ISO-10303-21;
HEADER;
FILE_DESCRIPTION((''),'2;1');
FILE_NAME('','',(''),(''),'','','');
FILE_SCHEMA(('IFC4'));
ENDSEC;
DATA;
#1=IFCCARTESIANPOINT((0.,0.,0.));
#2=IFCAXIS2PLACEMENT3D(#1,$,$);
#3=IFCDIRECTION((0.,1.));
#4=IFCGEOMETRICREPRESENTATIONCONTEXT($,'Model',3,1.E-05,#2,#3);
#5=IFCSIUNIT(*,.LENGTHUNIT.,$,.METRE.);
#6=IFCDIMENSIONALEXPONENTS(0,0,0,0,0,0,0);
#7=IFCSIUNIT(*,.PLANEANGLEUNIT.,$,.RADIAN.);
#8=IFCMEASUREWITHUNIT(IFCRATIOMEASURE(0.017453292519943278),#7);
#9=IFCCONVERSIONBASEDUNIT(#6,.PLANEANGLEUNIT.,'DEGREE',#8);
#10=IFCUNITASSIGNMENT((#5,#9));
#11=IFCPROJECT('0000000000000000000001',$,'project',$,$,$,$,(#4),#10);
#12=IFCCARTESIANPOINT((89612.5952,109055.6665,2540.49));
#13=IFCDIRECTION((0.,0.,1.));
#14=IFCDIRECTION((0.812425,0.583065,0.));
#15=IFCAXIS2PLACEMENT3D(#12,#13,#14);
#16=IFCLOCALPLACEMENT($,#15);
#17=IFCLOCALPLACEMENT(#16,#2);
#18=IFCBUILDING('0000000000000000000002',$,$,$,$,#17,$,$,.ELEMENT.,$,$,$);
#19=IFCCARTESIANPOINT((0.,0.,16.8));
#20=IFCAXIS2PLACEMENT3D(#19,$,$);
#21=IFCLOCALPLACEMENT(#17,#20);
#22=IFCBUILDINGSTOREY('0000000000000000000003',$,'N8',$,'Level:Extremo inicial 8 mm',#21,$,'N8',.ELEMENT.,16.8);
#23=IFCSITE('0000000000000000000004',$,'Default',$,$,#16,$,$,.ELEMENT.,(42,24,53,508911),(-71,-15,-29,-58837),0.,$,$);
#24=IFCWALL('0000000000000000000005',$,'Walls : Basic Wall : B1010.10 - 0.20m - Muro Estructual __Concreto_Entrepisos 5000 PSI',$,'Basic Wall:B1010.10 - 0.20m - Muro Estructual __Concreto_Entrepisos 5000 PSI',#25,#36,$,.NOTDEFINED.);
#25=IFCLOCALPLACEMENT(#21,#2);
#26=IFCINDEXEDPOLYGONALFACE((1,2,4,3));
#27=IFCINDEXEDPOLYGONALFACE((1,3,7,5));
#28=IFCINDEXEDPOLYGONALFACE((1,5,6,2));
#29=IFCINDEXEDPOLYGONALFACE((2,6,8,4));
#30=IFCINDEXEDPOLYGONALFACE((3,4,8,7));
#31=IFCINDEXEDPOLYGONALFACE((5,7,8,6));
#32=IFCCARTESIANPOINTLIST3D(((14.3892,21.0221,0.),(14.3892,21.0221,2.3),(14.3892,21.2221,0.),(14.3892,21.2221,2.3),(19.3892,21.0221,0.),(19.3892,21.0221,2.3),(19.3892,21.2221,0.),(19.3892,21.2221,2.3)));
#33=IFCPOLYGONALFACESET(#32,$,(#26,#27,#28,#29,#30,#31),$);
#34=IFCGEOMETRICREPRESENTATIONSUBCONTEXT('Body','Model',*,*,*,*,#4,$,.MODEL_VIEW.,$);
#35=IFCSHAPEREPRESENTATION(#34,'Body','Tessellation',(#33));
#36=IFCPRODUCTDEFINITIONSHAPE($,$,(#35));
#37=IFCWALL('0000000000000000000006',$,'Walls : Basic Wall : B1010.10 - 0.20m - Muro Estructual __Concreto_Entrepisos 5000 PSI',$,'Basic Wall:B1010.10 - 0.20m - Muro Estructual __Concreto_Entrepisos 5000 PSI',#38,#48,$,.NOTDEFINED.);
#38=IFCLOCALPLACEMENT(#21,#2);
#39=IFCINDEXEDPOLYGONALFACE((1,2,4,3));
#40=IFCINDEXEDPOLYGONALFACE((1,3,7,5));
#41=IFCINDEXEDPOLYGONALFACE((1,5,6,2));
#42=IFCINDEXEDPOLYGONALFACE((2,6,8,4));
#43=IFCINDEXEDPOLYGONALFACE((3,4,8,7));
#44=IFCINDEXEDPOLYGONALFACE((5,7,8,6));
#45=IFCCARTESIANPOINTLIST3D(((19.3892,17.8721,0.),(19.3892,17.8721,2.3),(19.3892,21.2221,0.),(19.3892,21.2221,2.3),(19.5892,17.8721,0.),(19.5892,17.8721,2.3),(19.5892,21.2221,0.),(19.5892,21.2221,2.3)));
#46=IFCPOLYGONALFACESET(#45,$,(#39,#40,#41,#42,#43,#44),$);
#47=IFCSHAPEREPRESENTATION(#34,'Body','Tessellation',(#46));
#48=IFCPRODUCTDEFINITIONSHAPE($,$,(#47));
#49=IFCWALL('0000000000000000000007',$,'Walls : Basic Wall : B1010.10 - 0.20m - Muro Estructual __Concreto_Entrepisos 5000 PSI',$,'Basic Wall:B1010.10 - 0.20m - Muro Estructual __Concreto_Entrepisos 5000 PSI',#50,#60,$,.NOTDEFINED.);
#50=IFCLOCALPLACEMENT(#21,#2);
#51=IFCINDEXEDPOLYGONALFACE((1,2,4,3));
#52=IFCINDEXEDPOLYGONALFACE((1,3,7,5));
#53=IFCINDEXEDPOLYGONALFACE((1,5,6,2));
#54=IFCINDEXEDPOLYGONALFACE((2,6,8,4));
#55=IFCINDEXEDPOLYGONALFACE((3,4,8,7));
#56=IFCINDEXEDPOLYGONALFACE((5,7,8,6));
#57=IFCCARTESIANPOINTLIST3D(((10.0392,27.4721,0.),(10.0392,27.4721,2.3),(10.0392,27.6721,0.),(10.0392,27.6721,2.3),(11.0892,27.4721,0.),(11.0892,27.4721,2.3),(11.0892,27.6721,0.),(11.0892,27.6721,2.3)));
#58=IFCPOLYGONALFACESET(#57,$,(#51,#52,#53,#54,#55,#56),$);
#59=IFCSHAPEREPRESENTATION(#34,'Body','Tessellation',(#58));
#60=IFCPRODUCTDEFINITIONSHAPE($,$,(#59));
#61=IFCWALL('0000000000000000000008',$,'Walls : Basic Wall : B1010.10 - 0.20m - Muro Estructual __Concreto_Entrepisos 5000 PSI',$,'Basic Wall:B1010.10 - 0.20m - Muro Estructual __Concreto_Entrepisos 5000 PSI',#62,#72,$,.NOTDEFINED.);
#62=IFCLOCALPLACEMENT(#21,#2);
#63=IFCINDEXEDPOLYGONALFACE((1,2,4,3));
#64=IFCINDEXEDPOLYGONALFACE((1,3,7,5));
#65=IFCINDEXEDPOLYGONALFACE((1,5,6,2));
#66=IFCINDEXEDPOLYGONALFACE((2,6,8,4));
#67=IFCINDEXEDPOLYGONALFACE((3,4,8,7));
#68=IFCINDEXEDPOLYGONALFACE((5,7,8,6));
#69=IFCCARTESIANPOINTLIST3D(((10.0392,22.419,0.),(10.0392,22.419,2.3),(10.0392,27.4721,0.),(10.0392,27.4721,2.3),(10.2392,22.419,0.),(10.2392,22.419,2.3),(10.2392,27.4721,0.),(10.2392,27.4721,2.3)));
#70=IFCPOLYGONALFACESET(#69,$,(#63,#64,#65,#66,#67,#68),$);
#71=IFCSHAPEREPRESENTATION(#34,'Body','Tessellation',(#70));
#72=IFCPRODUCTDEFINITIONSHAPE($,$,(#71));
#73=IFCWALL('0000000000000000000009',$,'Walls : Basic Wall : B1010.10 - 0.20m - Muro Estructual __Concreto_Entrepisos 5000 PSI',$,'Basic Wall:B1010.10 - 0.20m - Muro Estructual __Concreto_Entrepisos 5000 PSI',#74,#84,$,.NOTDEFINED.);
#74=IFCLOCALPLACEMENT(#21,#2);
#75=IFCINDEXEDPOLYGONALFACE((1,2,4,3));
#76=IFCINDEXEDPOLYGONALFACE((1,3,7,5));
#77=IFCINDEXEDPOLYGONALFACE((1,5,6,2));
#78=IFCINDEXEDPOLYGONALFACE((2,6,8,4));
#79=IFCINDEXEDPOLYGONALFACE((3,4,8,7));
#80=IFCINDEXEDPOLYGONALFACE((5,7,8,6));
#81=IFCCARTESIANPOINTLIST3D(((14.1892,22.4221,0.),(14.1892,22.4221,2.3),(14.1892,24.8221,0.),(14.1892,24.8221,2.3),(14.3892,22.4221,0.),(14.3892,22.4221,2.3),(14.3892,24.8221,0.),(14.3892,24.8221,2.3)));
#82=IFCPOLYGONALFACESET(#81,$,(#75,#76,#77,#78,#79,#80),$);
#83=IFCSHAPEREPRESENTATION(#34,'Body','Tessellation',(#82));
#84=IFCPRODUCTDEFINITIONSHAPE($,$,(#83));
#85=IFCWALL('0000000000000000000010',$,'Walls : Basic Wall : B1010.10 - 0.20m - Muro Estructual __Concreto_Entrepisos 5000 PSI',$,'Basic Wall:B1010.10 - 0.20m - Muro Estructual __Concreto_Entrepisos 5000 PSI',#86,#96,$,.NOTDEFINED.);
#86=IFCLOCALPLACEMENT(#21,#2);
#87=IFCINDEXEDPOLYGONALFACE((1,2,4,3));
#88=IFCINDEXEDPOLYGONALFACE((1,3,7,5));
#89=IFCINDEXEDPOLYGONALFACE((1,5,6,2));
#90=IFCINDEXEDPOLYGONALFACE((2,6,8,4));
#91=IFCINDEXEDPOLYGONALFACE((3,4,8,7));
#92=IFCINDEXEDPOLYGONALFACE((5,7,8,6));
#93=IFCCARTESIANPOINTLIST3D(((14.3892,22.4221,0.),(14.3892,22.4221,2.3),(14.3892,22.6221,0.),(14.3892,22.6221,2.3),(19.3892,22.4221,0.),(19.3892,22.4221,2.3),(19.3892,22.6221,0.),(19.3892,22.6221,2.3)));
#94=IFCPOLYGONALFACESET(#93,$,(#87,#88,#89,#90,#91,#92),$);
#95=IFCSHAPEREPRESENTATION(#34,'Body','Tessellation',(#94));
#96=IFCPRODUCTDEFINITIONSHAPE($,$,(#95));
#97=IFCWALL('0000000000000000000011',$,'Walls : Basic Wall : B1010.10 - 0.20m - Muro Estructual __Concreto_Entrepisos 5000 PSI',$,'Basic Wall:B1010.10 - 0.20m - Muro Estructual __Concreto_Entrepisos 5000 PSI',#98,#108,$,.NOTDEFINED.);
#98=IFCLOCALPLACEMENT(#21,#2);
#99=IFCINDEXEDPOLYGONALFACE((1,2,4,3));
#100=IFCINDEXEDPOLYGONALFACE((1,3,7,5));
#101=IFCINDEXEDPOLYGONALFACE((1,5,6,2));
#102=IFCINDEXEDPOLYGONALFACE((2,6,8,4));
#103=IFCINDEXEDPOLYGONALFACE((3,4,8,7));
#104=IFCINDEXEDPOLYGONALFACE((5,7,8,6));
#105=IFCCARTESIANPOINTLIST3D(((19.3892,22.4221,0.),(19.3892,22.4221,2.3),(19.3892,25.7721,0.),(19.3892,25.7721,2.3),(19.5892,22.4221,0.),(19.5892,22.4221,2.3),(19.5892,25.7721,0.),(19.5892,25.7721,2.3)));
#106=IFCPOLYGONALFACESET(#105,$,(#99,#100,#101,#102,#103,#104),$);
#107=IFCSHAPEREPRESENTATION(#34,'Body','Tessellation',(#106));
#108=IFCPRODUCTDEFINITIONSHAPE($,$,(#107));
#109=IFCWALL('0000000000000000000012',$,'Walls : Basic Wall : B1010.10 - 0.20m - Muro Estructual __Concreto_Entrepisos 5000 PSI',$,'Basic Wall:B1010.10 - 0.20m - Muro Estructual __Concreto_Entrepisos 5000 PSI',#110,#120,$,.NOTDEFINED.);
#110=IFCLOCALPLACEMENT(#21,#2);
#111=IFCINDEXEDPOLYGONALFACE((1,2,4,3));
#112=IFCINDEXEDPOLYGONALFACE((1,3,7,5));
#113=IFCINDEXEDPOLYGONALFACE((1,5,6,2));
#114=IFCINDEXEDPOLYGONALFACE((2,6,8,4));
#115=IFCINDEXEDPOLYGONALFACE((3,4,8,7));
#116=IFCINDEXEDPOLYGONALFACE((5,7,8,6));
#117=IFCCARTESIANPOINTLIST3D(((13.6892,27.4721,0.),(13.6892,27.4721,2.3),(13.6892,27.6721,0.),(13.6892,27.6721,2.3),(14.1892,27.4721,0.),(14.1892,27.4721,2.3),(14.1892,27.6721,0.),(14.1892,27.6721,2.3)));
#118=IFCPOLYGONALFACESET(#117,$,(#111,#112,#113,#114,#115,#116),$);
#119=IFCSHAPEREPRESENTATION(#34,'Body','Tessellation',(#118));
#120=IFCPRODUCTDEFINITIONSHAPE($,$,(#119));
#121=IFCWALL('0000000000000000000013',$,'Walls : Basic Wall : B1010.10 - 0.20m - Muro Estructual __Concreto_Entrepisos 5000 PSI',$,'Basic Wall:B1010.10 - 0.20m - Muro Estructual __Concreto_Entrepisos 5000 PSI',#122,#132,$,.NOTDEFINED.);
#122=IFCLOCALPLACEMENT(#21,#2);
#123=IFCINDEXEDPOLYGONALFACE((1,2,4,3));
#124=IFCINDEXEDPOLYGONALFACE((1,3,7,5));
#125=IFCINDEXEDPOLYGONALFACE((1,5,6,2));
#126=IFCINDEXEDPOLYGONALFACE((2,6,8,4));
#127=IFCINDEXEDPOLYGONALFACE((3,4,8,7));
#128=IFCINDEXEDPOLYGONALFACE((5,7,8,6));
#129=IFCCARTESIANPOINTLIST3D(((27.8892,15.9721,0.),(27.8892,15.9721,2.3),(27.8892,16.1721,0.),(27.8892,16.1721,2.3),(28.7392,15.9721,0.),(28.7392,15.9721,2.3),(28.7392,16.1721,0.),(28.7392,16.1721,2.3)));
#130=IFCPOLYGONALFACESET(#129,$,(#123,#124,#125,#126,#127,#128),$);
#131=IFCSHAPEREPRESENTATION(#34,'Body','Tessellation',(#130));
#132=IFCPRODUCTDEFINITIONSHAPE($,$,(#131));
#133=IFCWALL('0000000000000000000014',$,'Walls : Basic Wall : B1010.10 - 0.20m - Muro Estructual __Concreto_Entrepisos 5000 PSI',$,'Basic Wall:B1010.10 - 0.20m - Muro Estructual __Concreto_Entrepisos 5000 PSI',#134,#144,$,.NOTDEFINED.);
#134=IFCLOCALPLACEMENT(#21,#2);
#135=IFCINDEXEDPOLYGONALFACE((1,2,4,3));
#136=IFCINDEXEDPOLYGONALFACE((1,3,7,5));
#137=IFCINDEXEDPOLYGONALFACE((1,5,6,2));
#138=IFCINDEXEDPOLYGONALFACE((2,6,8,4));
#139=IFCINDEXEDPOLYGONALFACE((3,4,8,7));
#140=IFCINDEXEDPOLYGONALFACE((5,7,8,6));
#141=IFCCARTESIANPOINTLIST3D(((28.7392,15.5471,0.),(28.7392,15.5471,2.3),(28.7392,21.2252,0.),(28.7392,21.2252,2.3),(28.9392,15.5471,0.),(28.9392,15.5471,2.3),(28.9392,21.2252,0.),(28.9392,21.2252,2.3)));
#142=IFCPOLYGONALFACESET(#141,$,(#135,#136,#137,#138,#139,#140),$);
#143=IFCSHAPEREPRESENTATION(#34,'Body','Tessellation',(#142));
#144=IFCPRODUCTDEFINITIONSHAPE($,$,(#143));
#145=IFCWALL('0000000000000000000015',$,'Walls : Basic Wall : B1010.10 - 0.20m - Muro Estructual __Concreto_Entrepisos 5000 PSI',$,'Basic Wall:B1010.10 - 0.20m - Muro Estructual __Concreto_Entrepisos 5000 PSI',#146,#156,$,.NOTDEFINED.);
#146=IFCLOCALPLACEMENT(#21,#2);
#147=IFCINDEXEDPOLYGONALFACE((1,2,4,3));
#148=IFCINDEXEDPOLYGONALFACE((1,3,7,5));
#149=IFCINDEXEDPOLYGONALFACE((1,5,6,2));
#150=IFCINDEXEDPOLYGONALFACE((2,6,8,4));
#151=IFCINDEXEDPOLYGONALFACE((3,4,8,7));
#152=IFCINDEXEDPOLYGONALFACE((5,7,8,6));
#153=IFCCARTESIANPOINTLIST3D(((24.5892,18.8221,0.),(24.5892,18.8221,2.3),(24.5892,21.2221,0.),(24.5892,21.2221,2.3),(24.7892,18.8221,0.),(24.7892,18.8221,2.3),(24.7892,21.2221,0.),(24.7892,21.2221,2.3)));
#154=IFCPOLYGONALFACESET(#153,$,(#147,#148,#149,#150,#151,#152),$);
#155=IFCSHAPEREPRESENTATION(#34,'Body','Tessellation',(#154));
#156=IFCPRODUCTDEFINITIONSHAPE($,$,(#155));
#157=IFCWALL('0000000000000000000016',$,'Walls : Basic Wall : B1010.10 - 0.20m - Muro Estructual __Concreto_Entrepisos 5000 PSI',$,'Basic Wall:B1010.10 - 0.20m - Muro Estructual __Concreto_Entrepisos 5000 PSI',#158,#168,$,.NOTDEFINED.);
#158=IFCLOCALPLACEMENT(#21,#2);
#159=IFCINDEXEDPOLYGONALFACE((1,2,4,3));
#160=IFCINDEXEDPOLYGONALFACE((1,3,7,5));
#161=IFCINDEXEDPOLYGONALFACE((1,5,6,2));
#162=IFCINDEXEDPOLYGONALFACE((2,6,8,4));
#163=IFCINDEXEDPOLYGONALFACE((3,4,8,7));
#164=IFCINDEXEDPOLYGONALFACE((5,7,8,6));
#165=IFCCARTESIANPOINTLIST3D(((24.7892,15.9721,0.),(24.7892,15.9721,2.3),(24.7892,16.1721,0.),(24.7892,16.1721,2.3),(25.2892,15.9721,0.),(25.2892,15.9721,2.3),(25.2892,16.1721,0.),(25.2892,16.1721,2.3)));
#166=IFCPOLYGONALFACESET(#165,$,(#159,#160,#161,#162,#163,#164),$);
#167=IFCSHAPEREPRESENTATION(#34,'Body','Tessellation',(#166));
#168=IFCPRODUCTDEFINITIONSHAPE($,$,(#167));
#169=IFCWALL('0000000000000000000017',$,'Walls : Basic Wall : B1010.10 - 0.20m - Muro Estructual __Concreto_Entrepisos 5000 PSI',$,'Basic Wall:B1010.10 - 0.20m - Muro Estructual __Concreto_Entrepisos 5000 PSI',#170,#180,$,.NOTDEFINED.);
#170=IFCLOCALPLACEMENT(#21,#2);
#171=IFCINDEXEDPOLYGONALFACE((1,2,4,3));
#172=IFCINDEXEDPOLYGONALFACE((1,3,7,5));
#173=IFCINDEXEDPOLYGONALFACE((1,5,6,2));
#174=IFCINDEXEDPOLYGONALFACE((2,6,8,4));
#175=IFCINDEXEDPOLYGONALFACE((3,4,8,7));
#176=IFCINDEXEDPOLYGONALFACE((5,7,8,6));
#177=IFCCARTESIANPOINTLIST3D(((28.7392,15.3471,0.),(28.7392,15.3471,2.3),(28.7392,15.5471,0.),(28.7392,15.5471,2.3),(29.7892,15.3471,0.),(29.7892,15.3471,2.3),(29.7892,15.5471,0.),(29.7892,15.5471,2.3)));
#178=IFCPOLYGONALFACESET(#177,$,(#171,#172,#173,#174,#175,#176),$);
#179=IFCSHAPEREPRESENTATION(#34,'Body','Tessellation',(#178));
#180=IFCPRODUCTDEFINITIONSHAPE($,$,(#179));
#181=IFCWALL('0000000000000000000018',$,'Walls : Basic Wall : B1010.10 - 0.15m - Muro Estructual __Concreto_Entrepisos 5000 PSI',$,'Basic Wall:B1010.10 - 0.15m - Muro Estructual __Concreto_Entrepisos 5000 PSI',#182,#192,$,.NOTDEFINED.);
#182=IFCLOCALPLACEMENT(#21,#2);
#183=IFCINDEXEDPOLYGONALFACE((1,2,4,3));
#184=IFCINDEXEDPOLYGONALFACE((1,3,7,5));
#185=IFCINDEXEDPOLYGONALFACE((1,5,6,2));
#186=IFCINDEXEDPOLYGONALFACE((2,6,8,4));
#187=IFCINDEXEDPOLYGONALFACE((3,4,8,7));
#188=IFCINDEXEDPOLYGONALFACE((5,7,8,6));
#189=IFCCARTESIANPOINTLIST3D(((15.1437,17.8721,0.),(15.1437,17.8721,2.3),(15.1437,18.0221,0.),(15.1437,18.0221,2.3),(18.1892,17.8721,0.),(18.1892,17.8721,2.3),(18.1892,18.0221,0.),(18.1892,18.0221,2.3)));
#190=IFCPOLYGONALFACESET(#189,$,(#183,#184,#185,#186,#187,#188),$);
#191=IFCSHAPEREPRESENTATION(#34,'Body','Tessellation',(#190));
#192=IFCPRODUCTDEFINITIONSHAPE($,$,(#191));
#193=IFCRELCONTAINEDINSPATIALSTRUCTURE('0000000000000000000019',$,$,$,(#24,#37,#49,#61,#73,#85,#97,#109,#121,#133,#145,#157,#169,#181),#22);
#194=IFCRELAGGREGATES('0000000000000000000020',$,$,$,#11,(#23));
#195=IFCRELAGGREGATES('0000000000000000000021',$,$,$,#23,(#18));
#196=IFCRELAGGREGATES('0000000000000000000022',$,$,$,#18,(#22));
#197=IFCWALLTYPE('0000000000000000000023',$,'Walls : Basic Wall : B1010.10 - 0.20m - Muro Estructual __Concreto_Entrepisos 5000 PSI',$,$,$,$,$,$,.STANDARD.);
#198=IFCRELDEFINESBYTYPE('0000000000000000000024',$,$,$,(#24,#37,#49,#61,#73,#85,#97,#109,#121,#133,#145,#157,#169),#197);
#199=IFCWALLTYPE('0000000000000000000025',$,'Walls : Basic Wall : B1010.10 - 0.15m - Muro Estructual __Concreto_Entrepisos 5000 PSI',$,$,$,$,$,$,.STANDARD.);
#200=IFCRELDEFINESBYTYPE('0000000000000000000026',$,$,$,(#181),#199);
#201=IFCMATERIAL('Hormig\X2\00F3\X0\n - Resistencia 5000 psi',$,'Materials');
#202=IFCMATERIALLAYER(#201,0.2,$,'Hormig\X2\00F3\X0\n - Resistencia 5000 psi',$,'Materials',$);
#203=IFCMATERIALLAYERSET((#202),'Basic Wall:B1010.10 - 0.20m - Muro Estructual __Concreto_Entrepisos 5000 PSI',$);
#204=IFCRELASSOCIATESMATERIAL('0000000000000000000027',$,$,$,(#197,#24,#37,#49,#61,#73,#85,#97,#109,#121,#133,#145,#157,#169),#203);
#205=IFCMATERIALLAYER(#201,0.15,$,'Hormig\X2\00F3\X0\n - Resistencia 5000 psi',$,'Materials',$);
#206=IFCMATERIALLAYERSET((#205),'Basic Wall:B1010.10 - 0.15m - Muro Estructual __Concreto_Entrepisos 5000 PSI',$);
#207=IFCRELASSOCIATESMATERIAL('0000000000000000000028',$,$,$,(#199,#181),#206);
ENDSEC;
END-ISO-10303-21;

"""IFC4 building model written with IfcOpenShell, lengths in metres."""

from ifc_helpers import new_model, entity, si_unit, converted_unit, direction, frame, frame_2d, origin, place, context, subcontext, project, spatial, rectangle, extrude, material, layer, layer_set, layer_usage, type_object, element, save


model = new_model("IFC4")

# Units and contexts
model_context = context("Model", 3, precision=1e-05, world=origin(), true_north=direction((0.0, 1.0)))
body_context = subcontext(model_context, "Body", "Model", "MODEL_VIEW")
ifc_project = project(units=[si_unit("LENGTHUNIT", "METRE"), converted_unit("PLANEANGLEUNIT", "DEGREE", entity("IfcRatioMeasure", 0.017453292519943278), si_unit("PLANEANGLEUNIT", "RADIAN"), dimensions=[0, 0, 0, 0, 0, 0, 0])], contexts=[model_context])

# Site, building, storey
site_placement = place(None, frame((89612.5952, 109055.6665, 2540.49), z_axis=(0.0, 0.0, 1.0), x_axis=(0.812425, 0.583065, 0.0)))
site = spatial("IfcSite", under=ifc_project, at=site_placement, Name="Default", CompositionType="ELEMENT", RefLatitude=(42, 24, 53, 508911), RefLongitude=(-71, -15, -29, -58837), RefElevation=0.0)
building_placement = place(site_placement, origin())
building = spatial("IfcBuilding", under=site, at=building_placement, CompositionType="ELEMENT")
storey_placement = place(building_placement, frame((0.0, 0.0, 16.8)))
storey = spatial("IfcBuildingStorey", under=building, at=storey_placement, Name="N8", ObjectType="Level:Extremo inicial 8 mm", LongName="N8", CompositionType="ELEMENT", Elevation=16.8)

# Walls
ifc_material = material(Name="Hormigón - Resistencia 5000 psi", Category="Materials")
ifc_layer_1 = layer(ifc_material, 0.2, Name="Hormigón - Resistencia 5000 psi", Category="Materials")
ifc_layer_set_1 = layer_set([ifc_layer_1], Name="Basic Wall:B1010.10 - 0.20m - Muro Estructual __Concreto_Entrepisos 5000 PSI")
ifc_layer_usage_1 = layer_usage(ifc_layer_set_1, "AXIS2", "NEGATIVE", 0.1)
wall_type_1 = type_object("IfcWallType", Name="Walls : Basic Wall : B1010.10 - 0.20m - Muro Estructual __Concreto_Entrepisos 5000 PSI", PredefinedType="STANDARD", material=ifc_layer_set_1)
wall_1_placement = place(storey_placement, frame((14.3892, 21.1221, 0.0)))
element("IfcWall", 1, at=wall_1_placement, inside=storey, type_object=wall_type_1, material=ifc_layer_usage_1, Name="Walls : Basic Wall : B1010.10 - 0.20m - Muro Estructual __Concreto_Entrepisos 5000 PSI", ObjectType="Basic Wall:B1010.10 - 0.20m - Muro Estructual __Concreto_Entrepisos 5000 PSI", PredefinedType="NOTDEFINED", context=body_context, shape_type="SweptSolid", body=[
    extrude(rectangle(XDim=5.0, YDim=0.2, at=frame_2d((2.5, 0.0), x_axis=(-1.0, 0.0))), origin(), (0.0, 0.0, 1.0), 2.3),
])
ifc_layer_usage_2 = layer_usage(ifc_layer_set_1, "AXIS2", "NEGATIVE", 0.1)
wall_2_placement = place(storey_placement, frame((19.4892, 21.2221, 0.0), z_axis=(0.0, 0.0, 1.0), x_axis=(0.0, -1.0, 0.0)))
element("IfcWall", 2, at=wall_2_placement, inside=storey, type_object=wall_type_1, material=ifc_layer_usage_2, Name="Walls : Basic Wall : B1010.10 - 0.20m - Muro Estructual __Concreto_Entrepisos 5000 PSI", ObjectType="Basic Wall:B1010.10 - 0.20m - Muro Estructual __Concreto_Entrepisos 5000 PSI", PredefinedType="NOTDEFINED", context=body_context, shape_type="SweptSolid", body=[
    extrude(rectangle(XDim=3.35, YDim=0.2, at=frame_2d((1.675, 0.0), x_axis=(-1.0, 0.0))), origin(), (0.0, 0.0, 1.0), 2.3),
])
ifc_layer_usage_3 = layer_usage(ifc_layer_set_1, "AXIS2", "POSITIVE", -0.1)
wall_3_placement = place(storey_placement, frame((11.0892, 27.5721, 0.0), z_axis=(0.0, 0.0, 1.0), x_axis=(-1.0, 0.0, 0.0)))
element("IfcWall", 3, at=wall_3_placement, inside=storey, type_object=wall_type_1, material=ifc_layer_usage_3, Name="Walls : Basic Wall : B1010.10 - 0.20m - Muro Estructual __Concreto_Entrepisos 5000 PSI", ObjectType="Basic Wall:B1010.10 - 0.20m - Muro Estructual __Concreto_Entrepisos 5000 PSI", PredefinedType="NOTDEFINED", context=body_context, shape_type="SweptSolid", body=[
    extrude(rectangle(XDim=1.05, YDim=0.2, at=frame_2d((0.525, 0.0), x_axis=(-1.0, 0.0))), origin(), (0.0, 0.0, 1.0), 2.3),
])
ifc_layer_usage_4 = layer_usage(ifc_layer_set_1, "AXIS2", "POSITIVE", -0.1)
wall_4_placement = place(storey_placement, frame((10.1392, 27.4721, 0.0), z_axis=(0.0, 0.0, 1.0), x_axis=(0.0, -1.0, 0.0)))
element("IfcWall", 4, at=wall_4_placement, inside=storey, type_object=wall_type_1, material=ifc_layer_usage_4, Name="Walls : Basic Wall : B1010.10 - 0.20m - Muro Estructual __Concreto_Entrepisos 5000 PSI", ObjectType="Basic Wall:B1010.10 - 0.20m - Muro Estructual __Concreto_Entrepisos 5000 PSI", PredefinedType="NOTDEFINED", context=body_context, shape_type="SweptSolid", body=[
    extrude(rectangle(XDim=5.0531, YDim=0.2, at=frame_2d((2.5265, 0.0), x_axis=(-1.0, 0.0))), origin(), (0.0, 0.0, 1.0), 2.3),
])
ifc_layer_usage_5 = layer_usage(ifc_layer_set_1, "AXIS2", "POSITIVE", -0.1)
wall_5_placement = place(storey_placement, frame((14.2892, 24.8221, 0.0), z_axis=(0.0, 0.0, 1.0), x_axis=(0.0, -1.0, 0.0)))
element("IfcWall", 5, at=wall_5_placement, inside=storey, type_object=wall_type_1, material=ifc_layer_usage_5, Name="Walls : Basic Wall : B1010.10 - 0.20m - Muro Estructual __Concreto_Entrepisos 5000 PSI", ObjectType="Basic Wall:B1010.10 - 0.20m - Muro Estructual __Concreto_Entrepisos 5000 PSI", PredefinedType="NOTDEFINED", context=body_context, shape_type="SweptSolid", body=[
    extrude(rectangle(XDim=2.4, YDim=0.2, at=frame_2d((1.2, 0.0), x_axis=(-1.0, 0.0))), origin(), (0.0, 0.0, 1.0), 2.3),
])
ifc_layer_usage_6 = layer_usage(ifc_layer_set_1, "AXIS2", "POSITIVE", -0.1)
wall_6_placement = place(storey_placement, frame((14.3892, 22.5221, 0.0)))
element("IfcWall", 6, at=wall_6_placement, inside=storey, type_object=wall_type_1, material=ifc_layer_usage_6, Name="Walls : Basic Wall : B1010.10 - 0.20m - Muro Estructual __Concreto_Entrepisos 5000 PSI", ObjectType="Basic Wall:B1010.10 - 0.20m - Muro Estructual __Concreto_Entrepisos 5000 PSI", PredefinedType="NOTDEFINED", context=body_context, shape_type="SweptSolid", body=[
    extrude(rectangle(XDim=5.0, YDim=0.2, at=frame_2d((2.5, 0.0), x_axis=(-1.0, 0.0))), origin(), (0.0, 0.0, 1.0), 2.3),
])
ifc_layer_usage_7 = layer_usage(ifc_layer_set_1, "AXIS2", "POSITIVE", -0.1)
wall_7_placement = place(storey_placement, frame((19.4892, 22.4221, 0.0), z_axis=(0.0, 0.0, 1.0), x_axis=(0.0, 1.0, 0.0)))
element("IfcWall", 7, at=wall_7_placement, inside=storey, type_object=wall_type_1, material=ifc_layer_usage_7, Name="Walls : Basic Wall : B1010.10 - 0.20m - Muro Estructual __Concreto_Entrepisos 5000 PSI", ObjectType="Basic Wall:B1010.10 - 0.20m - Muro Estructual __Concreto_Entrepisos 5000 PSI", PredefinedType="NOTDEFINED", context=body_context, shape_type="SweptSolid", body=[
    extrude(rectangle(XDim=3.35, YDim=0.2, at=frame_2d((1.675, 0.0), x_axis=(-1.0, 0.0))), origin(), (0.0, 0.0, 1.0), 2.3),
])
ifc_layer_usage_8 = layer_usage(ifc_layer_set_1, "AXIS2", "POSITIVE", -0.1)
wall_8_placement = place(storey_placement, frame((13.6892, 27.5721, 0.0)))
element("IfcWall", 8, at=wall_8_placement, inside=storey, type_object=wall_type_1, material=ifc_layer_usage_8, Name="Walls : Basic Wall : B1010.10 - 0.20m - Muro Estructual __Concreto_Entrepisos 5000 PSI", ObjectType="Basic Wall:B1010.10 - 0.20m - Muro Estructual __Concreto_Entrepisos 5000 PSI", PredefinedType="NOTDEFINED", context=body_context, shape_type="SweptSolid", body=[
    extrude(rectangle(XDim=0.5, YDim=0.2, at=frame_2d((0.25, 0.0), x_axis=(-1.0, 0.0))), origin(), (0.0, 0.0, 1.0), 2.3),
])
ifc_layer_usage_9 = layer_usage(ifc_layer_set_1, "AXIS2", "POSITIVE", -0.1)
wall_9_placement = place(storey_placement, frame((27.8892, 16.0721, 0.0)))
element("IfcWall", 9, at=wall_9_placement, inside=storey, type_object=wall_type_1, material=ifc_layer_usage_9, Name="Walls : Basic Wall : B1010.10 - 0.20m - Muro Estructual __Concreto_Entrepisos 5000 PSI", ObjectType="Basic Wall:B1010.10 - 0.20m - Muro Estructual __Concreto_Entrepisos 5000 PSI", PredefinedType="NOTDEFINED", context=body_context, shape_type="SweptSolid", body=[
    extrude(rectangle(XDim=0.85, YDim=0.2, at=frame_2d((0.425, 0.0), x_axis=(-1.0, 0.0))), origin(), (0.0, 0.0, 1.0), 2.3),
])
ifc_layer_usage_10 = layer_usage(ifc_layer_set_1, "AXIS2", "POSITIVE", -0.1)
wall_10_placement = place(storey_placement, frame((28.8392, 15.5471, 0.0), z_axis=(0.0, 0.0, 1.0), x_axis=(0.0, 1.0, 0.0)))
element("IfcWall", 10, at=wall_10_placement, inside=storey, type_object=wall_type_1, material=ifc_layer_usage_10, Name="Walls : Basic Wall : B1010.10 - 0.20m - Muro Estructual __Concreto_Entrepisos 5000 PSI", ObjectType="Basic Wall:B1010.10 - 0.20m - Muro Estructual __Concreto_Entrepisos 5000 PSI", PredefinedType="NOTDEFINED", context=body_context, shape_type="SweptSolid", body=[
    extrude(rectangle(XDim=5.6781, YDim=0.2, at=frame_2d((2.839, 0.0), x_axis=(-1.0, 0.0))), origin(), (0.0, 0.0, 1.0), 2.3),
])
ifc_layer_usage_11 = layer_usage(ifc_layer_set_1, "AXIS2", "POSITIVE", -0.1)
wall_11_placement = place(storey_placement, frame((24.6892, 18.8221, 0.0), z_axis=(0.0, 0.0, 1.0), x_axis=(0.0, 1.0, 0.0)))
element("IfcWall", 11, at=wall_11_placement, inside=storey, type_object=wall_type_1, material=ifc_layer_usage_11, Name="Walls : Basic Wall : B1010.10 - 0.20m - Muro Estructual __Concreto_Entrepisos 5000 PSI", ObjectType="Basic Wall:B1010.10 - 0.20m - Muro Estructual __Concreto_Entrepisos 5000 PSI", PredefinedType="NOTDEFINED", context=body_context, shape_type="SweptSolid", body=[
    extrude(rectangle(XDim=2.4, YDim=0.2, at=frame_2d((1.2, 0.0), x_axis=(-1.0, 0.0))), origin(), (0.0, 0.0, 1.0), 2.3),
])
ifc_layer_usage_12 = layer_usage(ifc_layer_set_1, "AXIS2", "POSITIVE", -0.1)
wall_12_placement = place(storey_placement, frame((25.2892, 16.0721, 0.0), z_axis=(0.0, 0.0, 1.0), x_axis=(-1.0, 0.0, 0.0)))
element("IfcWall", 12, at=wall_12_placement, inside=storey, type_object=wall_type_1, material=ifc_layer_usage_12, Name="Walls : Basic Wall : B1010.10 - 0.20m - Muro Estructual __Concreto_Entrepisos 5000 PSI", ObjectType="Basic Wall:B1010.10 - 0.20m - Muro Estructual __Concreto_Entrepisos 5000 PSI", PredefinedType="NOTDEFINED", context=body_context, shape_type="SweptSolid", body=[
    extrude(rectangle(XDim=0.5, YDim=0.2, at=frame_2d((0.25, 0.0), x_axis=(-1.0, 0.0))), origin(), (0.0, 0.0, 1.0), 2.3),
])
ifc_layer_usage_13 = layer_usage(ifc_layer_set_1, "AXIS2", "NEGATIVE", 0.1)
wall_13_placement = place(storey_placement, frame((29.7892, 15.4471, 0.0), z_axis=(0.0, 0.0, 1.0), x_axis=(-1.0, 0.0, 0.0)))
element("IfcWall", 13, at=wall_13_placement, inside=storey, type_object=wall_type_1, material=ifc_layer_usage_13, Name="Walls : Basic Wall : B1010.10 - 0.20m - Muro Estructual __Concreto_Entrepisos 5000 PSI", ObjectType="Basic Wall:B1010.10 - 0.20m - Muro Estructual __Concreto_Entrepisos 5000 PSI", PredefinedType="NOTDEFINED", context=body_context, shape_type="SweptSolid", body=[
    extrude(rectangle(XDim=1.05, YDim=0.2, at=frame_2d((0.525, 0.0), x_axis=(-1.0, 0.0))), origin(), (0.0, 0.0, 1.0), 2.3),
])
ifc_layer_2 = layer(ifc_material, 0.15, Name="Hormigón - Resistencia 5000 psi", Category="Materials")
ifc_layer_set_2 = layer_set([ifc_layer_2], Name="Basic Wall:B1010.10 - 0.15m - Muro Estructual __Concreto_Entrepisos 5000 PSI")
ifc_layer_usage_14 = layer_usage(ifc_layer_set_2, "AXIS2", "NEGATIVE", 0.075)
wall_type_2 = type_object("IfcWallType", Name="Walls : Basic Wall : B1010.10 - 0.15m - Muro Estructual __Concreto_Entrepisos 5000 PSI", PredefinedType="STANDARD", material=ifc_layer_set_2)
wall_14_placement = place(storey_placement, frame((18.1892, 17.9471, 0.0), z_axis=(0.0, 0.0, 1.0), x_axis=(-1.0, 0.0, 0.0)))
element("IfcWall", 14, at=wall_14_placement, inside=storey, type_object=wall_type_2, material=ifc_layer_usage_14, Name="Walls : Basic Wall : B1010.10 - 0.15m - Muro Estructual __Concreto_Entrepisos 5000 PSI", ObjectType="Basic Wall:B1010.10 - 0.15m - Muro Estructual __Concreto_Entrepisos 5000 PSI", PredefinedType="NOTDEFINED", context=body_context, shape_type="SweptSolid", body=[
    extrude(rectangle(XDim=3.0455, YDim=0.15, at=frame_2d((1.5228, 0.0), x_axis=(-1.0, 0.0))), origin(), (0.0, 0.0, 1.0), 2.3),
])

save(model, "model.ifc")
